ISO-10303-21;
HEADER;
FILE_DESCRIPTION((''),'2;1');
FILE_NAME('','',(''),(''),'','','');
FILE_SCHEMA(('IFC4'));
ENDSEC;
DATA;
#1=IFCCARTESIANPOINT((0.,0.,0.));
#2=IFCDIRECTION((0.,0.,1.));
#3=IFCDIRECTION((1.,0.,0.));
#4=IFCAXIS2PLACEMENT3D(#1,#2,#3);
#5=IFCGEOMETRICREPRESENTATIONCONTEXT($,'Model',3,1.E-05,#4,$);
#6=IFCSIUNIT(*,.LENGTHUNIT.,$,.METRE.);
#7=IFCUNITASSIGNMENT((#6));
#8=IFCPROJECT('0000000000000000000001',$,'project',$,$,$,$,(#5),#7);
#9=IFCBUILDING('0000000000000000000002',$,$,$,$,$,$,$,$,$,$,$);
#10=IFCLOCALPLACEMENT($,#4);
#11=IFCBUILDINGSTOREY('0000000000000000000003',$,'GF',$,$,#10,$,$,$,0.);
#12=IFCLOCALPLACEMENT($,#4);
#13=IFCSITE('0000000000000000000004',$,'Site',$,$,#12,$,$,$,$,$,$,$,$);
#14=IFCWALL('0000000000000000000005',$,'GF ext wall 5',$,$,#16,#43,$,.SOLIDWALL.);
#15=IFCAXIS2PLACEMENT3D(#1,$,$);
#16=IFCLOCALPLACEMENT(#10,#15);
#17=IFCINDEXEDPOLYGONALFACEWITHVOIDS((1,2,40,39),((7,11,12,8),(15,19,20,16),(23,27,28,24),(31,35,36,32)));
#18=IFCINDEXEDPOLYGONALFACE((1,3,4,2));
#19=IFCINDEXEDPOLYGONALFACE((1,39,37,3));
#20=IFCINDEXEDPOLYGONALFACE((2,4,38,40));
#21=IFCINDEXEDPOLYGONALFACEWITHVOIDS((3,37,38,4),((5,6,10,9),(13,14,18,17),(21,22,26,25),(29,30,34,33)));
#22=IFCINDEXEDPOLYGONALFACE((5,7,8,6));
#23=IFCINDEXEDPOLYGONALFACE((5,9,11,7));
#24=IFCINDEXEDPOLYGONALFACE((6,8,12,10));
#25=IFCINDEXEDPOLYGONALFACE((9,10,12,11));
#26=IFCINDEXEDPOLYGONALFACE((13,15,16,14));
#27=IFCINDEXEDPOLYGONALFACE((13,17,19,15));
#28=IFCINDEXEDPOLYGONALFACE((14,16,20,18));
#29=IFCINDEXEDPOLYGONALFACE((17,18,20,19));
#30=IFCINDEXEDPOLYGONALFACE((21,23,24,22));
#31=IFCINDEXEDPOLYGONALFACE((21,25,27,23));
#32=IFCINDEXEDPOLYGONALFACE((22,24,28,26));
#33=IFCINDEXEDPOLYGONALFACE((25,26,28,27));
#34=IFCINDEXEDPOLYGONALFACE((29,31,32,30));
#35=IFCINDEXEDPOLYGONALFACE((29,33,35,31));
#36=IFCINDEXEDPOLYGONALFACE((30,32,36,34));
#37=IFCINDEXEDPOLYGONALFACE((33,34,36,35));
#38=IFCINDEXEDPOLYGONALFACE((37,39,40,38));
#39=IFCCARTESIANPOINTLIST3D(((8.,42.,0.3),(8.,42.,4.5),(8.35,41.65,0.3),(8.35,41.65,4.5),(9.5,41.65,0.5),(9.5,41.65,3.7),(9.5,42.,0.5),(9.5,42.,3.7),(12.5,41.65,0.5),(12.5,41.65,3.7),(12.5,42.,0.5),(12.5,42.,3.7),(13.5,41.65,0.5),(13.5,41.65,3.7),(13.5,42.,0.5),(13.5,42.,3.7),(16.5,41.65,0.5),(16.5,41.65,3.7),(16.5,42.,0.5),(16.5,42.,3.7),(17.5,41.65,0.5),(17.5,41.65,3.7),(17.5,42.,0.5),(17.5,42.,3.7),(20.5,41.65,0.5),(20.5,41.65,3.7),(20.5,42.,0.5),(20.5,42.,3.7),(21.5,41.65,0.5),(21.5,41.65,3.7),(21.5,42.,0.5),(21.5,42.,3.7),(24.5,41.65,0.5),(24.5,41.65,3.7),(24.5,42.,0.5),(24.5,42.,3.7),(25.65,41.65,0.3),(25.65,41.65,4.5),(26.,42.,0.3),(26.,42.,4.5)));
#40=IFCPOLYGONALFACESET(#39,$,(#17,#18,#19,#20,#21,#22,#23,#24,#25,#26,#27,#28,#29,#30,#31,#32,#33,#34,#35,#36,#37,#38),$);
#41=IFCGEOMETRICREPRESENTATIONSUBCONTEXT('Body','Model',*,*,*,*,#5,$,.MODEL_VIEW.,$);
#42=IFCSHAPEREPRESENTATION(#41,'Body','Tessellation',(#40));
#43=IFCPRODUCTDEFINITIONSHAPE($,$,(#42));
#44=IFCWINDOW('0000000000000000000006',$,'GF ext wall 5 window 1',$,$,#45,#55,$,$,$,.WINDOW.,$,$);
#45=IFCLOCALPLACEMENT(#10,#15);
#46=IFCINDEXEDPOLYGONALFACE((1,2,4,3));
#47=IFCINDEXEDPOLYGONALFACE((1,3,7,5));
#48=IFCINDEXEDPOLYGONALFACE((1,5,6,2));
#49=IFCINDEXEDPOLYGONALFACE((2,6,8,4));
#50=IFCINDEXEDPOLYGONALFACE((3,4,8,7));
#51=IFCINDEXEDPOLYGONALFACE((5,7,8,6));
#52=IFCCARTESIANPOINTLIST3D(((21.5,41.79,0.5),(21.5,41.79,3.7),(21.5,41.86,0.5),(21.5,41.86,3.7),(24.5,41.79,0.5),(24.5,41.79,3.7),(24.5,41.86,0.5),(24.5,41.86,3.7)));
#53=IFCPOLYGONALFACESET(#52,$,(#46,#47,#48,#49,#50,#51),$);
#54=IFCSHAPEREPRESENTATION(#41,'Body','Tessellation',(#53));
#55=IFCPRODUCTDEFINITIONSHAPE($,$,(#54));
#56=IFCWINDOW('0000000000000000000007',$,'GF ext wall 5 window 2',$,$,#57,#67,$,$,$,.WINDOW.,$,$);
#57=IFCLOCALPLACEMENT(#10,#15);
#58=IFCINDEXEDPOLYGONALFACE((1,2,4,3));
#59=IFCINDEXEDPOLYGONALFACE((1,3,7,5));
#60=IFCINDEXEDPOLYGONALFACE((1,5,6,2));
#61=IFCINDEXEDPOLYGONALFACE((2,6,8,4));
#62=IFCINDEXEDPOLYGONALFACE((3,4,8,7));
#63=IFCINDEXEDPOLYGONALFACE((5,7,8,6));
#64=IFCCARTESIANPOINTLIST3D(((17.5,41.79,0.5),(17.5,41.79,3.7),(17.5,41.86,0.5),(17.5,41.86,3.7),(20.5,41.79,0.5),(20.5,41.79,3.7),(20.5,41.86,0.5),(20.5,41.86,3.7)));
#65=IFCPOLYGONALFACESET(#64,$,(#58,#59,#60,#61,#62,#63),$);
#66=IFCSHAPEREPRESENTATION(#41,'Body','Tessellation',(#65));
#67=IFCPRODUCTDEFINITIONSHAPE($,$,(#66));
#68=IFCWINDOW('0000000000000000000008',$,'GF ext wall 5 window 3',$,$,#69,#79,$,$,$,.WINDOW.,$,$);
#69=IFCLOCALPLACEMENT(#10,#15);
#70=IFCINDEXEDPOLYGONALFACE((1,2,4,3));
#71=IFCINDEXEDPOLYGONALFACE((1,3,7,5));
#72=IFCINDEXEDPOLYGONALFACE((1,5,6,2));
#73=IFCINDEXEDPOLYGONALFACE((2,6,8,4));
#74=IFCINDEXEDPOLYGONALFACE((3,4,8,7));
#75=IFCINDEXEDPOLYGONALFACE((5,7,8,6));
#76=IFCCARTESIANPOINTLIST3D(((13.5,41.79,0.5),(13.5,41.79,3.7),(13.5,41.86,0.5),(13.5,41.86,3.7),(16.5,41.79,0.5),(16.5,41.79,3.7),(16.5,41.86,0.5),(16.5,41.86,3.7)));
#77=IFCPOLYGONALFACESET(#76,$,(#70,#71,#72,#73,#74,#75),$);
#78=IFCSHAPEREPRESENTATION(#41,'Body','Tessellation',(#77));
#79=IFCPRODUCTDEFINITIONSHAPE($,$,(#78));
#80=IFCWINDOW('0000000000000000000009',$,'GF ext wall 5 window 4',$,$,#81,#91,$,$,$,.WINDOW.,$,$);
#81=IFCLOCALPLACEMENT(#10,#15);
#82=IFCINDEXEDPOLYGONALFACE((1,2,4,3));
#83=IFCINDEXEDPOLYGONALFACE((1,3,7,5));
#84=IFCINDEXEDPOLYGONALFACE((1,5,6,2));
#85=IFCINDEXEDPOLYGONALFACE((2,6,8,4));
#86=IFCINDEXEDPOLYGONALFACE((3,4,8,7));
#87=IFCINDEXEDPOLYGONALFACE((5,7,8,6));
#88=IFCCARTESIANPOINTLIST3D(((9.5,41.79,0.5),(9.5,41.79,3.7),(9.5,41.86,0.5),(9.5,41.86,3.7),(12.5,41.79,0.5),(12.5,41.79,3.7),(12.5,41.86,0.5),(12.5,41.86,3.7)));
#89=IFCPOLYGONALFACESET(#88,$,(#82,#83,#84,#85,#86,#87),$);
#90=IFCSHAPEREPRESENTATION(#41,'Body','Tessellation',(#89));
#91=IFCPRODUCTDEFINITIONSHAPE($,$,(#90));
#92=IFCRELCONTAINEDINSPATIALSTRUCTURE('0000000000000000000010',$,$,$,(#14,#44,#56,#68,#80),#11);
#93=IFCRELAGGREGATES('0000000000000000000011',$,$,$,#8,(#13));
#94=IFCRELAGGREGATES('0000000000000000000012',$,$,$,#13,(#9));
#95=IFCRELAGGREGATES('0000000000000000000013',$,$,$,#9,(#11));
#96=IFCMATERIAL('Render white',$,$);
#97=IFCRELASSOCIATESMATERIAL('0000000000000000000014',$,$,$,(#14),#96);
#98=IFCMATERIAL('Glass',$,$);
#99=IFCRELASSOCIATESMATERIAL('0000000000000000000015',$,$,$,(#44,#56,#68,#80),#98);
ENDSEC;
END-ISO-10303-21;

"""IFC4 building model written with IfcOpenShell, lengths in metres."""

from ifc_helpers import new_model, si_unit, frame, origin_with_axes, place, context, subcontext, project, spatial, polyline, outline, extrude, material, element, fill, save


model = new_model("IFC4")

# Units and contexts
model_context = context("Model", 3, precision=1e-05, world=origin_with_axes())
body_context = subcontext(model_context, "Body", "Model", "MODEL_VIEW")
ifc_project = project(units=[si_unit("LENGTHUNIT", "METRE")], contexts=[model_context])

# Site, building, storey
site_placement = place(None, origin_with_axes())
site = spatial("IfcSite", under=ifc_project, at=site_placement, Name="Site")
building = spatial("IfcBuilding", under=site)
storey_placement = place(None, origin_with_axes())
storey = spatial("IfcBuildingStorey", under=building, at=storey_placement, Name="GF", Elevation=0.0)

# Wall, openings, windows
ifc_material_1 = material(Name="Render white")
wall_1_placement = place(storey_placement, origin_with_axes())
wall_1 = element("IfcWall", 1, at=wall_1_placement, inside=storey, material=ifc_material_1, Name="GF ext wall 5", PredefinedType="SOLIDWALL", context=body_context, shape_type="SweptSolid", body=[
    extrude(outline(polyline([(26.0, 42.0), (8.0, 42.0), (8.35, 41.65), (25.65, 41.65), (26.0, 42.0)])), frame((0.0, 0.0, 0.3), z_axis=(0.0, 0.0, 1.0), x_axis=(1.0, 0.0, 0.0)), (0.0, 0.0, 1.0), 4.2),
])
opening_1_placement = place(wall_1_placement, origin_with_axes())
opening_1 = element("IfcOpeningElement", 2, at=opening_1_placement, cuts=wall_1, context=body_context, shape_type="SweptSolid", body=[
    extrude(outline(polyline([(24.5, 42.05), (21.5, 42.05), (21.5, 41.6), (24.5, 41.6), (24.5, 42.05)])), frame((0.0, 0.0, 0.5), z_axis=(0.0, 0.0, 1.0), x_axis=(1.0, 0.0, 0.0)), (0.0, 0.0, 1.0), 3.2),
])
opening_2_placement = place(wall_1_placement, origin_with_axes())
opening_2 = element("IfcOpeningElement", 3, at=opening_2_placement, cuts=wall_1, context=body_context, shape_type="SweptSolid", body=[
    extrude(outline(polyline([(20.5, 42.05), (17.5, 42.05), (17.5, 41.6), (20.5, 41.6), (20.5, 42.05)])), frame((0.0, 0.0, 0.5), z_axis=(0.0, 0.0, 1.0), x_axis=(1.0, 0.0, 0.0)), (0.0, 0.0, 1.0), 3.2),
])
opening_3_placement = place(wall_1_placement, origin_with_axes())
opening_3 = element("IfcOpeningElement", 4, at=opening_3_placement, cuts=wall_1, context=body_context, shape_type="SweptSolid", body=[
    extrude(outline(polyline([(16.5, 42.05), (13.5, 42.05), (13.5, 41.6), (16.5, 41.6), (16.5, 42.05)])), frame((0.0, 0.0, 0.5), z_axis=(0.0, 0.0, 1.0), x_axis=(1.0, 0.0, 0.0)), (0.0, 0.0, 1.0), 3.2),
])
opening_4_placement = place(wall_1_placement, origin_with_axes())
opening_4 = element("IfcOpeningElement", 5, at=opening_4_placement, cuts=wall_1, context=body_context, shape_type="SweptSolid", body=[
    extrude(outline(polyline([(12.5, 42.05), (9.5, 42.05), (9.5, 41.6), (12.5, 41.6), (12.5, 42.05)])), frame((0.0, 0.0, 0.5), z_axis=(0.0, 0.0, 1.0), x_axis=(1.0, 0.0, 0.0)), (0.0, 0.0, 1.0), 3.2),
])
ifc_material_2 = material(Name="Glass")
window_1_placement = place(storey_placement, origin_with_axes())
window_1 = element("IfcWindow", 6, at=window_1_placement, inside=storey, material=ifc_material_2, Name="GF ext wall 5 window 1", PredefinedType="WINDOW", context=body_context, shape_type="SweptSolid", body=[
    extrude(outline(polyline([(24.5, 41.86), (21.5, 41.86), (21.5, 41.79), (24.5, 41.79), (24.5, 41.86)])), frame((0.0, 0.0, 0.5), z_axis=(0.0, 0.0, 1.0), x_axis=(1.0, 0.0, 0.0)), (0.0, 0.0, 1.0), 3.2),
])
fill(opening_1, window_1)
window_2_placement = place(storey_placement, origin_with_axes())
window_2 = element("IfcWindow", 7, at=window_2_placement, inside=storey, material=ifc_material_2, Name="GF ext wall 5 window 2", PredefinedType="WINDOW", context=body_context, shape_type="SweptSolid", body=[
    extrude(outline(polyline([(20.5, 41.86), (17.5, 41.86), (17.5, 41.79), (20.5, 41.79), (20.5, 41.86)])), frame((0.0, 0.0, 0.5), z_axis=(0.0, 0.0, 1.0), x_axis=(1.0, 0.0, 0.0)), (0.0, 0.0, 1.0), 3.2),
])
fill(opening_2, window_2)
window_3_placement = place(storey_placement, origin_with_axes())
window_3 = element("IfcWindow", 8, at=window_3_placement, inside=storey, material=ifc_material_2, Name="GF ext wall 5 window 3", PredefinedType="WINDOW", context=body_context, shape_type="SweptSolid", body=[
    extrude(outline(polyline([(16.5, 41.86), (13.5, 41.86), (13.5, 41.79), (16.5, 41.79), (16.5, 41.86)])), frame((0.0, 0.0, 0.5), z_axis=(0.0, 0.0, 1.0), x_axis=(1.0, 0.0, 0.0)), (0.0, 0.0, 1.0), 3.2),
])
fill(opening_3, window_3)
window_4_placement = place(storey_placement, origin_with_axes())
window_4 = element("IfcWindow", 9, at=window_4_placement, inside=storey, material=ifc_material_2, Name="GF ext wall 5 window 4", PredefinedType="WINDOW", context=body_context, shape_type="SweptSolid", body=[
    extrude(outline(polyline([(12.5, 41.86), (9.5, 41.86), (9.5, 41.79), (12.5, 41.79), (12.5, 41.86)])), frame((0.0, 0.0, 0.5), z_axis=(0.0, 0.0, 1.0), x_axis=(1.0, 0.0, 0.0)), (0.0, 0.0, 1.0), 3.2),
])
fill(opening_4, window_4)

save(model, "model.ifc")
